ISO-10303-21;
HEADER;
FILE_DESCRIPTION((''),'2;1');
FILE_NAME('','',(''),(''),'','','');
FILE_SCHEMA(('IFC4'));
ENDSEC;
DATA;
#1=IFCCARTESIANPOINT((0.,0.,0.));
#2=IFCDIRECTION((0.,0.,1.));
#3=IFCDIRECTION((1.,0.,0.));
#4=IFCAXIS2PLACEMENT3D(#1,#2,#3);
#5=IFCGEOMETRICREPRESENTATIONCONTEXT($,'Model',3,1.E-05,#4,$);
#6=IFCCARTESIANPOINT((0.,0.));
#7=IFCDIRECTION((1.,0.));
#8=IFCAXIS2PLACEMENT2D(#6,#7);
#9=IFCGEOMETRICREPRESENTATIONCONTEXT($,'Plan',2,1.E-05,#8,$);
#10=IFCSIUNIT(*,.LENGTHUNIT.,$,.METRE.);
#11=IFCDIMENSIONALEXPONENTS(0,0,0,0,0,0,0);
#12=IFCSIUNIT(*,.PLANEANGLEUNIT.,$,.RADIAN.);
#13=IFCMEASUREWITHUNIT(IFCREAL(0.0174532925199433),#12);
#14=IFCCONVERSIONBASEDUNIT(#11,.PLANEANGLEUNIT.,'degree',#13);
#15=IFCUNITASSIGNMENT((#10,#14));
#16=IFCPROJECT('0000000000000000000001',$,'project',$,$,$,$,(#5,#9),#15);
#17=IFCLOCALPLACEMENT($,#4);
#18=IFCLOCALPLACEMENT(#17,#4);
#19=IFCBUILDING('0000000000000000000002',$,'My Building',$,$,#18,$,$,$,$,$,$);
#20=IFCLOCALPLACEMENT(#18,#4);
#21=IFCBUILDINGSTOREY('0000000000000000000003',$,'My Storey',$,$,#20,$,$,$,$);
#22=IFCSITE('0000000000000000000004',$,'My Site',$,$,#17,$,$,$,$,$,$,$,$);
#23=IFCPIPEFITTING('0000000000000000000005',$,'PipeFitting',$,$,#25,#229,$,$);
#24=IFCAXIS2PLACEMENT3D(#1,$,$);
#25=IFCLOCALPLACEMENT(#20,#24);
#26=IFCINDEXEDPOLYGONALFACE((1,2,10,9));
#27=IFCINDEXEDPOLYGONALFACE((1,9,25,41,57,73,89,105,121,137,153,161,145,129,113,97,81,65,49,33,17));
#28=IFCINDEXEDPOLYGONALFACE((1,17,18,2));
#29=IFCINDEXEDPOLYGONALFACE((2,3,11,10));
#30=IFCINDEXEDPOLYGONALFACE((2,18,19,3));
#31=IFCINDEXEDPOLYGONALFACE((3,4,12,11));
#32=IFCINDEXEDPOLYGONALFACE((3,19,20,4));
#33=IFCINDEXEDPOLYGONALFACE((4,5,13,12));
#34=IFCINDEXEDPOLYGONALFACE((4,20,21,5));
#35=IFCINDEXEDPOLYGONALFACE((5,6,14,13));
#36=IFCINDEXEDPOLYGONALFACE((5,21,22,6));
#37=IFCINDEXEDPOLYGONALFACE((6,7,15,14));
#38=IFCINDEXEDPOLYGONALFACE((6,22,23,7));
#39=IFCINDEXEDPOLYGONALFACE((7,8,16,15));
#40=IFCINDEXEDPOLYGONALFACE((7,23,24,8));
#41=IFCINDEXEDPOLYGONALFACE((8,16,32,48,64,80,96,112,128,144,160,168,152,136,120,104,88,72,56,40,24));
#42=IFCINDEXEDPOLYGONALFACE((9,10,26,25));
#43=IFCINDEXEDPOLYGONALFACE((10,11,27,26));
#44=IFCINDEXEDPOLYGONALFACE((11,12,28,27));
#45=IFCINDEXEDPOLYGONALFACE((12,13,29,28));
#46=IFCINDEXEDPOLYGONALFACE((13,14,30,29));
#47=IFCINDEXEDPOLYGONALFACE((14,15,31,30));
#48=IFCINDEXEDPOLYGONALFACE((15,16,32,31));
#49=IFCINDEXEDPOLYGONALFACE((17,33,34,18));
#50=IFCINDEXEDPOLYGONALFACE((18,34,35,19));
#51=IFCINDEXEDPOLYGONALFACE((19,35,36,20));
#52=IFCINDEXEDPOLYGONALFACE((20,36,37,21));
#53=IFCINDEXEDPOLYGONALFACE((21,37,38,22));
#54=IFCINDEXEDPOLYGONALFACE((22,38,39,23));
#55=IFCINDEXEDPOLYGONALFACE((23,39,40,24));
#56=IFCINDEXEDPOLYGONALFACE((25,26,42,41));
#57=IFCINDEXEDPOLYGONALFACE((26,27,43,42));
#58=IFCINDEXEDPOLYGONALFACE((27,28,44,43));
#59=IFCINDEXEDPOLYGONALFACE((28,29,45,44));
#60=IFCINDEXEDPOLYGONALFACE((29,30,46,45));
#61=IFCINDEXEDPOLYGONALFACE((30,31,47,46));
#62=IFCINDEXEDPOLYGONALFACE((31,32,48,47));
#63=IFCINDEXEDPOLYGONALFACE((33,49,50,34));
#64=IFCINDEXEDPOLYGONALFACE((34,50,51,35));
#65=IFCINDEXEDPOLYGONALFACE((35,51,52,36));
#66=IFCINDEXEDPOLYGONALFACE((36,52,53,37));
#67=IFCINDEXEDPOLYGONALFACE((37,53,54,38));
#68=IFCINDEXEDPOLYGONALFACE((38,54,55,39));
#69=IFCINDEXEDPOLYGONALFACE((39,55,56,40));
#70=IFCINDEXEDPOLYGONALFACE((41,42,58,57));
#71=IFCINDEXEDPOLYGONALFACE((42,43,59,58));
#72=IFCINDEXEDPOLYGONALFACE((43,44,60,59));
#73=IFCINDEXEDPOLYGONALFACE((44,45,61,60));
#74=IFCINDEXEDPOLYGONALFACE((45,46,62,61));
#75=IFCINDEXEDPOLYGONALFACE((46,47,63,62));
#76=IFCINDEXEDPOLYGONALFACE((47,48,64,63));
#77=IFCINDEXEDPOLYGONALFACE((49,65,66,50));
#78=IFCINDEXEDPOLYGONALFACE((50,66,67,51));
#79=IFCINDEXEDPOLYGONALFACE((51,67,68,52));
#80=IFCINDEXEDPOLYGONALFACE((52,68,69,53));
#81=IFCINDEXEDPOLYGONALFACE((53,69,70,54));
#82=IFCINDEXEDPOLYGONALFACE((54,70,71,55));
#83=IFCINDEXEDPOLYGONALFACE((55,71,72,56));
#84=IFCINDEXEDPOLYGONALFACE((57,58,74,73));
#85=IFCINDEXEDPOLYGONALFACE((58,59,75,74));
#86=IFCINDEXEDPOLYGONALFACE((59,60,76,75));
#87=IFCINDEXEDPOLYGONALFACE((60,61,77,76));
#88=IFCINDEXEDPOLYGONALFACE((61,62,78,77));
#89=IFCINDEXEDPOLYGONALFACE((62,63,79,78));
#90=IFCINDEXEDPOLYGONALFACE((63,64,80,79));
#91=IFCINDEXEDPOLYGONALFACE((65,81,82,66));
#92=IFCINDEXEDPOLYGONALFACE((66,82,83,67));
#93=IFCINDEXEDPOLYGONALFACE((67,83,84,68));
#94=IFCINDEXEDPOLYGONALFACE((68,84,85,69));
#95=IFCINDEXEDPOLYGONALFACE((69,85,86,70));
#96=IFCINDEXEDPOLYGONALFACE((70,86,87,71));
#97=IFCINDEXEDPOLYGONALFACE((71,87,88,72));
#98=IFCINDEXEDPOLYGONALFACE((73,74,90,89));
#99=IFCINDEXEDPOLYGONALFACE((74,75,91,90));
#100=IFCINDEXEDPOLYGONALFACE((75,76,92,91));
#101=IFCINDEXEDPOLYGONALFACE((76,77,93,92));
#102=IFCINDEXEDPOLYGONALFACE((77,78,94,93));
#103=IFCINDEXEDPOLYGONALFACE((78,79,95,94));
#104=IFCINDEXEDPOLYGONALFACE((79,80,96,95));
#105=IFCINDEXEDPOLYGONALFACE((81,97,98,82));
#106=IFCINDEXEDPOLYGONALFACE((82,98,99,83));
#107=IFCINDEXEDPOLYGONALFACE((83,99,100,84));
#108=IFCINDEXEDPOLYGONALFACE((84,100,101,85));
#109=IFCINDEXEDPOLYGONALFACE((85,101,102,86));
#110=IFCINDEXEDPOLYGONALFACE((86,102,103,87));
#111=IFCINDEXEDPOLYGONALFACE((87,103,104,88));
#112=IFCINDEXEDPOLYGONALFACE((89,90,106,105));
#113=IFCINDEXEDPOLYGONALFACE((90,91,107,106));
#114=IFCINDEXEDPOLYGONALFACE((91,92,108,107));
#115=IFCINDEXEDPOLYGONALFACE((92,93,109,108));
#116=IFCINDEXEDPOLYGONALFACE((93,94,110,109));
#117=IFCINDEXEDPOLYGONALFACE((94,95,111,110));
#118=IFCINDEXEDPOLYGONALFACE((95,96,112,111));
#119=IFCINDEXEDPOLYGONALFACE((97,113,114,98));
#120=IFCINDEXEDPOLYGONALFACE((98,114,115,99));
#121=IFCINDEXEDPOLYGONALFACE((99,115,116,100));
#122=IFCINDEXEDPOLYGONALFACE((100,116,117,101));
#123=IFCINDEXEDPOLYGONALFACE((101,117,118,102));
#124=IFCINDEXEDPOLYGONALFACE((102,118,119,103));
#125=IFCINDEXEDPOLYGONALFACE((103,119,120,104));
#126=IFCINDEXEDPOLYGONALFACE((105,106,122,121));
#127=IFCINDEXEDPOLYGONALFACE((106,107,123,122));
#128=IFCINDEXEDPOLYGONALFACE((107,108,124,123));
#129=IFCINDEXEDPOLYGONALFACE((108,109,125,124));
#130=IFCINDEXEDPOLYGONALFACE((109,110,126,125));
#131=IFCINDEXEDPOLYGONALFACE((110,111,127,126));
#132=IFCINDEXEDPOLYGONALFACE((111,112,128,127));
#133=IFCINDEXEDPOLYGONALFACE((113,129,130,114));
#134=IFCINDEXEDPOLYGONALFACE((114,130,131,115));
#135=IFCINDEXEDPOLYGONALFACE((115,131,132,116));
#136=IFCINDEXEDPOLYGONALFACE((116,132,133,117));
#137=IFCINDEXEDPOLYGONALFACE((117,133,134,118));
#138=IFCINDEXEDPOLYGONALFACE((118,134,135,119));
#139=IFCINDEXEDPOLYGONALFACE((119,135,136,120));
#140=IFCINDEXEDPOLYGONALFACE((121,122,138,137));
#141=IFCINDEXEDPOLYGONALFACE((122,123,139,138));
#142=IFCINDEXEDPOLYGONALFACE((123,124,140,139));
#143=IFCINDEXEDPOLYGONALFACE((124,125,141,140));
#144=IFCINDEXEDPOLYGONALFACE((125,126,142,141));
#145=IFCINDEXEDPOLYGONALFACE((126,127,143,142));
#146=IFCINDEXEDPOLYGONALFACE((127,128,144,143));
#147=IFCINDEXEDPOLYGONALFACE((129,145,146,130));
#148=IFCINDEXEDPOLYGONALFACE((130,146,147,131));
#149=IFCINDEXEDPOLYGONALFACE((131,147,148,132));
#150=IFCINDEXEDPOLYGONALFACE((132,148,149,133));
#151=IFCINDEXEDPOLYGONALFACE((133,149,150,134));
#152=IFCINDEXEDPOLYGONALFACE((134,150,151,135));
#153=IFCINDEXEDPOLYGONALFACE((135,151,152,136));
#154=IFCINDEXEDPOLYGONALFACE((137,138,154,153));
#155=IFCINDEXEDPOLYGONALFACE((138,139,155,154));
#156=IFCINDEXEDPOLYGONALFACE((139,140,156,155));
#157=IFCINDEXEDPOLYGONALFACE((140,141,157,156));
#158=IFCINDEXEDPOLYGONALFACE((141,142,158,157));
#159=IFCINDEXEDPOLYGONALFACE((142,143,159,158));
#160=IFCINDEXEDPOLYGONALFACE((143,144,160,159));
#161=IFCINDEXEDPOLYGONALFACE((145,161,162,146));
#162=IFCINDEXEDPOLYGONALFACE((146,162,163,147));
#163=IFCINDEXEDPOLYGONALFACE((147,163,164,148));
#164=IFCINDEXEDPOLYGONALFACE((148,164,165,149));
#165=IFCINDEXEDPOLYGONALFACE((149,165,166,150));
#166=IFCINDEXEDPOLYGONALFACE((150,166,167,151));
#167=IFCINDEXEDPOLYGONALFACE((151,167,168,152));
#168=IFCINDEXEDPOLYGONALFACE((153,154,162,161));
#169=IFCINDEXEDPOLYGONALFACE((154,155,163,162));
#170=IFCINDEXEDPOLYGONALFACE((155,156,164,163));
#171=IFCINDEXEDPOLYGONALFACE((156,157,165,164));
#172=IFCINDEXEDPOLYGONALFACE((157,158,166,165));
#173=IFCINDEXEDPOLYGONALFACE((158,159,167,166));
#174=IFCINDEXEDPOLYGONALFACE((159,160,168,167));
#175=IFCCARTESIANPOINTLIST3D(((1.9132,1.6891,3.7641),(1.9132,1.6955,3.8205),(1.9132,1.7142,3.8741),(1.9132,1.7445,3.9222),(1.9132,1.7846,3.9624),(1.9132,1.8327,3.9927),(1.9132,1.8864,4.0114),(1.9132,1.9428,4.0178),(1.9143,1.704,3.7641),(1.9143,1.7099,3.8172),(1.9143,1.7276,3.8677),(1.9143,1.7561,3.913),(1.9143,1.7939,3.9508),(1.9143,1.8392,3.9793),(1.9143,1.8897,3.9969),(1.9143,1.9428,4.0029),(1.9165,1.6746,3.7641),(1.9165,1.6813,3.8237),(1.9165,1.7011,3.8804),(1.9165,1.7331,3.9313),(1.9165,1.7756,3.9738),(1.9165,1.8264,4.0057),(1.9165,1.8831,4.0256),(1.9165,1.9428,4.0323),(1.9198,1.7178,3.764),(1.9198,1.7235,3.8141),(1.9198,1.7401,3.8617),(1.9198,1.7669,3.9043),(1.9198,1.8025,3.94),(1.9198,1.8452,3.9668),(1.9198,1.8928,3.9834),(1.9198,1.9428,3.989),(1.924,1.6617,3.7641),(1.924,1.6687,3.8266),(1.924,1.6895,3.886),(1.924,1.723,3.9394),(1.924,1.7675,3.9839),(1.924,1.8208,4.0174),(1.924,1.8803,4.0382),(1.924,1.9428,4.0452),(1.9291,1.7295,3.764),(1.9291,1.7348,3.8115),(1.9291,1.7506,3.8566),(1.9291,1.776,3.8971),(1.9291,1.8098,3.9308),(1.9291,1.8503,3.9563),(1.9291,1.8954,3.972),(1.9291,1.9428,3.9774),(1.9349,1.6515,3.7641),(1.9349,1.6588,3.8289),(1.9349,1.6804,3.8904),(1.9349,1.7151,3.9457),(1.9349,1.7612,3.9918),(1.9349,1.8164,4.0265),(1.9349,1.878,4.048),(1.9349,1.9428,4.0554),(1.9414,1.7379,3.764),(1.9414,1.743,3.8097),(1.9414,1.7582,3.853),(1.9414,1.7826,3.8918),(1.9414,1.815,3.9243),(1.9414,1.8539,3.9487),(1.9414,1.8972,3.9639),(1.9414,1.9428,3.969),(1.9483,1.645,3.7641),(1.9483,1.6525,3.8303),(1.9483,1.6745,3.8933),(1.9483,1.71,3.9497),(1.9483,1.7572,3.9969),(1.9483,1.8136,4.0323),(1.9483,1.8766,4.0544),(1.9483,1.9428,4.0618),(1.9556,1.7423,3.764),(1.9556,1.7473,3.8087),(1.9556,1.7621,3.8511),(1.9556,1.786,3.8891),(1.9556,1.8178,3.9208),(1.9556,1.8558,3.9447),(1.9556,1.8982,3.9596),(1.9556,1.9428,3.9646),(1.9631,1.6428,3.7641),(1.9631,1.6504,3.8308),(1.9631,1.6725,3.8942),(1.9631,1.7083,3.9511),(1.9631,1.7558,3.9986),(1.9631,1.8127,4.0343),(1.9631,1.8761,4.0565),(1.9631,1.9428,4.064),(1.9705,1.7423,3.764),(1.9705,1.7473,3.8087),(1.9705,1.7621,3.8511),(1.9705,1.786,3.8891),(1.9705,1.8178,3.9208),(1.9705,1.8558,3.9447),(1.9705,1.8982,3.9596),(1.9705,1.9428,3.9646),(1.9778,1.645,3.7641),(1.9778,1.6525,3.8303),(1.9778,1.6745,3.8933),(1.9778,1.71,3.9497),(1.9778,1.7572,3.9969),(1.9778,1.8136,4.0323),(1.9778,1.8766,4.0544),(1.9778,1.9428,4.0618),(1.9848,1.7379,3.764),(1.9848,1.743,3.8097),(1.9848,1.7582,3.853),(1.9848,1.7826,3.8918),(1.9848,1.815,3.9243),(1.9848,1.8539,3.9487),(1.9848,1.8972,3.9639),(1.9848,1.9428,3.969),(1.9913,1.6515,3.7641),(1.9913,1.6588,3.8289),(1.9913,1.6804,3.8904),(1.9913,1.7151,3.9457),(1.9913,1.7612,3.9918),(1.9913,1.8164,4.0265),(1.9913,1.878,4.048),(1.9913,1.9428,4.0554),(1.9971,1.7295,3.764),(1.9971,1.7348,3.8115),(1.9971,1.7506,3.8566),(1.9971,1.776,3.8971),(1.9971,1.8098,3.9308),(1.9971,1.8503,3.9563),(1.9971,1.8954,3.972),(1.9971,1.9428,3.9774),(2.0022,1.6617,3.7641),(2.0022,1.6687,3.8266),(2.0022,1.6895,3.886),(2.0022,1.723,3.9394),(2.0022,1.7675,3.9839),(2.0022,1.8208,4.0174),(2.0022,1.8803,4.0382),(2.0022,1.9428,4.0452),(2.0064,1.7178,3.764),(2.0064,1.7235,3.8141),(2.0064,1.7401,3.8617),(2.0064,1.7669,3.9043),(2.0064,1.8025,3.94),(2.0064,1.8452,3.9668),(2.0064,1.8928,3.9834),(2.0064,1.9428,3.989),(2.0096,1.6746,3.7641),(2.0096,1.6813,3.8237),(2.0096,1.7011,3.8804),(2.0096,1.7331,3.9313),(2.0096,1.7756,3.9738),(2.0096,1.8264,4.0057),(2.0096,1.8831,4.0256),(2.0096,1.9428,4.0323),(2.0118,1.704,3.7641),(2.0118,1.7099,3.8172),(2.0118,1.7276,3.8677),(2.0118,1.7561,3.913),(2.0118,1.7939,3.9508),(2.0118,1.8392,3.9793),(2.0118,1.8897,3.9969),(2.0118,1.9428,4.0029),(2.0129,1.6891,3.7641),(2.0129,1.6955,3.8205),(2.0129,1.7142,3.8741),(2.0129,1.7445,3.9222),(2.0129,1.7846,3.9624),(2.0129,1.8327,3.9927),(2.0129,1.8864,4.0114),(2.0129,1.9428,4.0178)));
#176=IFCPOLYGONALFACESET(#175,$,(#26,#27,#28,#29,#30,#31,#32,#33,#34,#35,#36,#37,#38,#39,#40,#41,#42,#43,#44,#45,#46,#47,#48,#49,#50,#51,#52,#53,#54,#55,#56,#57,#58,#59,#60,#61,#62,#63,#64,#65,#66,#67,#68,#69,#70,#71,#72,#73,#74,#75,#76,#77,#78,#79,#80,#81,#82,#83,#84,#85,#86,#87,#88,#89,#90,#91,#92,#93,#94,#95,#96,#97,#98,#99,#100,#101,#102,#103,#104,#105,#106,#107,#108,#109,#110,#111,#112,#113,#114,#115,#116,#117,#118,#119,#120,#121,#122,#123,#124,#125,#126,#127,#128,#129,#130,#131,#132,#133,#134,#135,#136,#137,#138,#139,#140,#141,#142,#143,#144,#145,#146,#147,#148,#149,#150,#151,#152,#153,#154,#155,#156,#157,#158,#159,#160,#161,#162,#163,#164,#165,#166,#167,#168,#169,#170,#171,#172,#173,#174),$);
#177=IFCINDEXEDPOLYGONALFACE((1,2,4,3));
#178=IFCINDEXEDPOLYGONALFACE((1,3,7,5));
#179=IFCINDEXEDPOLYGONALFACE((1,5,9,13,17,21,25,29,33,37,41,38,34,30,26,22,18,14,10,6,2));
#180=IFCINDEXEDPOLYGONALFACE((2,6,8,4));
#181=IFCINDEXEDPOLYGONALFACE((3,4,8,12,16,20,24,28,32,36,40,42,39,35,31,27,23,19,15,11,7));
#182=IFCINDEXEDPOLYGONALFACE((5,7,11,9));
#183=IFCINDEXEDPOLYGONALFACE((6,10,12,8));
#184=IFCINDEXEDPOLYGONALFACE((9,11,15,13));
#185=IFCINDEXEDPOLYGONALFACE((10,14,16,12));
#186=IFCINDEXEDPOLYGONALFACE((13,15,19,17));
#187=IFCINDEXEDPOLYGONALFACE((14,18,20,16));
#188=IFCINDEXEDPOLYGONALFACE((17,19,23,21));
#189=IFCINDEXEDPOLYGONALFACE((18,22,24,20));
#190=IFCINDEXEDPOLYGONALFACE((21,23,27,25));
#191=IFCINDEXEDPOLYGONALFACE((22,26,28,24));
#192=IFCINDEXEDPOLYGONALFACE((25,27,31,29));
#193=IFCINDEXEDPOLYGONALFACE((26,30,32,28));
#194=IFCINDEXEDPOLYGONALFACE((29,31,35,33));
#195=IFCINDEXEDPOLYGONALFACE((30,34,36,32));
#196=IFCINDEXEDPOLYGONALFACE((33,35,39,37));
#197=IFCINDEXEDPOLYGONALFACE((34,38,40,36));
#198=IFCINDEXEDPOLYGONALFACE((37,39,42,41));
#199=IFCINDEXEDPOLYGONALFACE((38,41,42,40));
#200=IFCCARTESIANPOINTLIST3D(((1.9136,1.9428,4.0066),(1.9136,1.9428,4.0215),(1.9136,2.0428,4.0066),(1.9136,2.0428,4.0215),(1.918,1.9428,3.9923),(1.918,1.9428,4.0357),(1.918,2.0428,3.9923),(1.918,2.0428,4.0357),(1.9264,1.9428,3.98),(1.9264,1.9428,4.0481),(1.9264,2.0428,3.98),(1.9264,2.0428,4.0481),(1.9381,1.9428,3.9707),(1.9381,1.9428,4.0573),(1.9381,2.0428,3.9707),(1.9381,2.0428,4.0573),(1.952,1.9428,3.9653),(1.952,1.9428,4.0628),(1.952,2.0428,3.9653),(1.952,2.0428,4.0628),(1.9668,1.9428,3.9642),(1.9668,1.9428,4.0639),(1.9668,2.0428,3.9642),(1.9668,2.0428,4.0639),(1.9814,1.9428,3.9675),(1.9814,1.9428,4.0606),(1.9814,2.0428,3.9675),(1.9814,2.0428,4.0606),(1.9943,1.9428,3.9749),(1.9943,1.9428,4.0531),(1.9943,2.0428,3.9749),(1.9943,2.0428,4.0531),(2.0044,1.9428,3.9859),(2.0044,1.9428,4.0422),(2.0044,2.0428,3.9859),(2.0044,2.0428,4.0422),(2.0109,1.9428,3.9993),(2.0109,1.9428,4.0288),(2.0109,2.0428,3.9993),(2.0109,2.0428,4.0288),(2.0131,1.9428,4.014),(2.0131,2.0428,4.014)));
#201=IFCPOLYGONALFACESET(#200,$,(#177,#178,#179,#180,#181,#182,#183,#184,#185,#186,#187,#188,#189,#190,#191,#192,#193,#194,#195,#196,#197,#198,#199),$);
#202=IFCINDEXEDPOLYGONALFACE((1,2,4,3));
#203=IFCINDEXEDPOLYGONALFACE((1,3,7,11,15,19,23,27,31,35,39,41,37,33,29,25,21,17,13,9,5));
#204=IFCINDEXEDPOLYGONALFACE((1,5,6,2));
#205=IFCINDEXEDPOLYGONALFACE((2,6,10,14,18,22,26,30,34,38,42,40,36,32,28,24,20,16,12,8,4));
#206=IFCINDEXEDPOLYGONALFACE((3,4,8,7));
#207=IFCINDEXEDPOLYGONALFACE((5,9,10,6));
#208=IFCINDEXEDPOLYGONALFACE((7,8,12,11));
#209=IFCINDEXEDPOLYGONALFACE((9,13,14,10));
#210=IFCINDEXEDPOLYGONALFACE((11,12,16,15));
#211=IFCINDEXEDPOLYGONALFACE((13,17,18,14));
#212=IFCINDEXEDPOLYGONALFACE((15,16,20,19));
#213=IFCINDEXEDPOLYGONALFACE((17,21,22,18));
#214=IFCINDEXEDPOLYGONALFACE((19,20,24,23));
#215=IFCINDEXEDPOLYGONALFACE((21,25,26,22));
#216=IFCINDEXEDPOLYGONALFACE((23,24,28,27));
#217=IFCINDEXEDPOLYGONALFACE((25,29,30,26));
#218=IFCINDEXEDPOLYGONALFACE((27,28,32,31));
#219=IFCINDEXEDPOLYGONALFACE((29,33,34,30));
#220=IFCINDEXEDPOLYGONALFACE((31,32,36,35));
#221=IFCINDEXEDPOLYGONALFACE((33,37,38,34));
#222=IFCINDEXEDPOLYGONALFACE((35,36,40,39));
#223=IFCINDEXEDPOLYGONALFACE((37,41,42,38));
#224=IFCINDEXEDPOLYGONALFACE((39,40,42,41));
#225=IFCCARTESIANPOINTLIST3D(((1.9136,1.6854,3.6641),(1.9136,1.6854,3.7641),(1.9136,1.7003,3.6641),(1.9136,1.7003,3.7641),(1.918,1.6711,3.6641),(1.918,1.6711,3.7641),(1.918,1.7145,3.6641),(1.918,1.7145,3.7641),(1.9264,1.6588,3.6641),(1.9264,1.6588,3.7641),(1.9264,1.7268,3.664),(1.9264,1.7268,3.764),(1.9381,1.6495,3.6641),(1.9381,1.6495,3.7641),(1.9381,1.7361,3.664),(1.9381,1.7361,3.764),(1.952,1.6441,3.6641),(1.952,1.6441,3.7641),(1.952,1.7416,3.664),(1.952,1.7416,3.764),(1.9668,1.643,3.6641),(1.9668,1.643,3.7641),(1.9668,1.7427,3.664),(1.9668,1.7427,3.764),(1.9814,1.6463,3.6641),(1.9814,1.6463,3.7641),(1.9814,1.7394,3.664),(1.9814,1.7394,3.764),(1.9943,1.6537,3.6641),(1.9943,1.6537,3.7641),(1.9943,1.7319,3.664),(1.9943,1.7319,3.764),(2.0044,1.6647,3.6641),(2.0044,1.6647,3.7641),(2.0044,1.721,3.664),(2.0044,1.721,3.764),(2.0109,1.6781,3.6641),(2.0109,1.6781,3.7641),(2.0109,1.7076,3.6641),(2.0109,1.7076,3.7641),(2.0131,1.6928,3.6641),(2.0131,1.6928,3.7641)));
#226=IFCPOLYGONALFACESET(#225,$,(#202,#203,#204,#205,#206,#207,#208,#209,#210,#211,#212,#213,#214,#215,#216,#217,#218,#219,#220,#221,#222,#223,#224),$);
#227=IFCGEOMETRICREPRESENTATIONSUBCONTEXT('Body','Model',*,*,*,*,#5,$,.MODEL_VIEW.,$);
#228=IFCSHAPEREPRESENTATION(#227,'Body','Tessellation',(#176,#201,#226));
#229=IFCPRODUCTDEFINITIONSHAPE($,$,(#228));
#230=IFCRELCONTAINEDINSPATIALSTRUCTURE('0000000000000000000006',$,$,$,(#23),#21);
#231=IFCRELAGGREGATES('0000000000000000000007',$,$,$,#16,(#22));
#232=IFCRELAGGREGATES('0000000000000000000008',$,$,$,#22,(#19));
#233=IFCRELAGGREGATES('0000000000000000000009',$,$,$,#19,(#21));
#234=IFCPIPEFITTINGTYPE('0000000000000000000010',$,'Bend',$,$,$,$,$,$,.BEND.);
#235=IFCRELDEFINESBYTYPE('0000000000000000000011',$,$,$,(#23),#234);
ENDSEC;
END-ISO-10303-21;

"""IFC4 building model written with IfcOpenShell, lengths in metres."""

from ifc_helpers import new_model, entity, si_unit, converted_unit, frame, origin_with_axes, origin_2d_with_axis, place, context, subcontext, project, spatial, circle, extrude, source, transform, mapped, type_object, type_shapes, element, save


model = new_model("IFC4")

# Units and contexts
model_context = context("Model", 3, precision=1e-05, world=origin_with_axes())
plan_context = context("Plan", 2, precision=1e-05, world=origin_2d_with_axis())
body_context = subcontext(model_context, "Body", "Model", "MODEL_VIEW")
ifc_project = project(units=[si_unit("LENGTHUNIT", "METRE"), converted_unit("PLANEANGLEUNIT", "degree", entity("IfcReal", 0.0174532925199433), si_unit("PLANEANGLEUNIT", "RADIAN"), dimensions=[0, 0, 0, 0, 0, 0, 0])], contexts=[model_context, plan_context])

# Site, building, storey
site_placement = place(None, origin_with_axes())
site = spatial("IfcSite", under=ifc_project, at=site_placement, Name="My Site")
building_placement = place(site_placement, origin_with_axes())
building = spatial("IfcBuilding", under=site, at=building_placement, Name="My Building")
storey_placement = place(building_placement, origin_with_axes())
storey = spatial("IfcBuildingStorey", under=building, at=storey_placement, Name="My Storey")

# Pipe fitting
pipe_fitting_type_1 = type_object("IfcPipeFittingType", Name="Bend", PredefinedType="BEND")
shared_shape_1 = source(origin_with_axes(), body_context, "Body", "SolidModel", [
    entity("IfcSweptDiskSolid", entity("IfcIndexedPolyCurve", entity("IfcCartesianPointList3D", [[0.0, 0.0, 0.1], [0.0, -0.0732, 0.2768], [0.0, -0.25, 0.35]]), [entity("IfcArcIndex", [1, 2, 3])]), 0.05),
    extrude(circle(Radius=0.05), origin_with_axes(), (0.0, 0.0, 1.0), 0.1),
    extrude(circle(Radius=0.05), frame((0.0, -0.25, 0.35), z_axis=(0.0, -1.0, 0.000038), x_axis=(1.0, 0.0, 0.0)), (0.0, 0.0, 1.0), 0.1),
])
type_shapes(pipe_fitting_type_1, [shared_shape_1])
for number, where, z_axis, x_axis, name in (
    (1, (1.9631, 2.0428, 4.014), (0.0, -1.0, 0.0), (1.0, 0.0, 0.0), "PipeFitting"),
):
    element("IfcPipeFitting", number, at=place(storey_placement, frame(where, z_axis=z_axis, x_axis=x_axis)), inside=storey, type_object=pipe_fitting_type_1, Name=name, context=body_context, shape_type="MappedRepresentation", body=[
        mapped(shared_shape_1, transform((0.0, 0.0, 0.0), x_axis=(1.0, 0.0, 0.0), y_axis=(0.0, 1.0, 0.0), z_axis=(0.0, 0.0, 1.0), scale=1.0)),
    ])

save(model, "model.ifc")
